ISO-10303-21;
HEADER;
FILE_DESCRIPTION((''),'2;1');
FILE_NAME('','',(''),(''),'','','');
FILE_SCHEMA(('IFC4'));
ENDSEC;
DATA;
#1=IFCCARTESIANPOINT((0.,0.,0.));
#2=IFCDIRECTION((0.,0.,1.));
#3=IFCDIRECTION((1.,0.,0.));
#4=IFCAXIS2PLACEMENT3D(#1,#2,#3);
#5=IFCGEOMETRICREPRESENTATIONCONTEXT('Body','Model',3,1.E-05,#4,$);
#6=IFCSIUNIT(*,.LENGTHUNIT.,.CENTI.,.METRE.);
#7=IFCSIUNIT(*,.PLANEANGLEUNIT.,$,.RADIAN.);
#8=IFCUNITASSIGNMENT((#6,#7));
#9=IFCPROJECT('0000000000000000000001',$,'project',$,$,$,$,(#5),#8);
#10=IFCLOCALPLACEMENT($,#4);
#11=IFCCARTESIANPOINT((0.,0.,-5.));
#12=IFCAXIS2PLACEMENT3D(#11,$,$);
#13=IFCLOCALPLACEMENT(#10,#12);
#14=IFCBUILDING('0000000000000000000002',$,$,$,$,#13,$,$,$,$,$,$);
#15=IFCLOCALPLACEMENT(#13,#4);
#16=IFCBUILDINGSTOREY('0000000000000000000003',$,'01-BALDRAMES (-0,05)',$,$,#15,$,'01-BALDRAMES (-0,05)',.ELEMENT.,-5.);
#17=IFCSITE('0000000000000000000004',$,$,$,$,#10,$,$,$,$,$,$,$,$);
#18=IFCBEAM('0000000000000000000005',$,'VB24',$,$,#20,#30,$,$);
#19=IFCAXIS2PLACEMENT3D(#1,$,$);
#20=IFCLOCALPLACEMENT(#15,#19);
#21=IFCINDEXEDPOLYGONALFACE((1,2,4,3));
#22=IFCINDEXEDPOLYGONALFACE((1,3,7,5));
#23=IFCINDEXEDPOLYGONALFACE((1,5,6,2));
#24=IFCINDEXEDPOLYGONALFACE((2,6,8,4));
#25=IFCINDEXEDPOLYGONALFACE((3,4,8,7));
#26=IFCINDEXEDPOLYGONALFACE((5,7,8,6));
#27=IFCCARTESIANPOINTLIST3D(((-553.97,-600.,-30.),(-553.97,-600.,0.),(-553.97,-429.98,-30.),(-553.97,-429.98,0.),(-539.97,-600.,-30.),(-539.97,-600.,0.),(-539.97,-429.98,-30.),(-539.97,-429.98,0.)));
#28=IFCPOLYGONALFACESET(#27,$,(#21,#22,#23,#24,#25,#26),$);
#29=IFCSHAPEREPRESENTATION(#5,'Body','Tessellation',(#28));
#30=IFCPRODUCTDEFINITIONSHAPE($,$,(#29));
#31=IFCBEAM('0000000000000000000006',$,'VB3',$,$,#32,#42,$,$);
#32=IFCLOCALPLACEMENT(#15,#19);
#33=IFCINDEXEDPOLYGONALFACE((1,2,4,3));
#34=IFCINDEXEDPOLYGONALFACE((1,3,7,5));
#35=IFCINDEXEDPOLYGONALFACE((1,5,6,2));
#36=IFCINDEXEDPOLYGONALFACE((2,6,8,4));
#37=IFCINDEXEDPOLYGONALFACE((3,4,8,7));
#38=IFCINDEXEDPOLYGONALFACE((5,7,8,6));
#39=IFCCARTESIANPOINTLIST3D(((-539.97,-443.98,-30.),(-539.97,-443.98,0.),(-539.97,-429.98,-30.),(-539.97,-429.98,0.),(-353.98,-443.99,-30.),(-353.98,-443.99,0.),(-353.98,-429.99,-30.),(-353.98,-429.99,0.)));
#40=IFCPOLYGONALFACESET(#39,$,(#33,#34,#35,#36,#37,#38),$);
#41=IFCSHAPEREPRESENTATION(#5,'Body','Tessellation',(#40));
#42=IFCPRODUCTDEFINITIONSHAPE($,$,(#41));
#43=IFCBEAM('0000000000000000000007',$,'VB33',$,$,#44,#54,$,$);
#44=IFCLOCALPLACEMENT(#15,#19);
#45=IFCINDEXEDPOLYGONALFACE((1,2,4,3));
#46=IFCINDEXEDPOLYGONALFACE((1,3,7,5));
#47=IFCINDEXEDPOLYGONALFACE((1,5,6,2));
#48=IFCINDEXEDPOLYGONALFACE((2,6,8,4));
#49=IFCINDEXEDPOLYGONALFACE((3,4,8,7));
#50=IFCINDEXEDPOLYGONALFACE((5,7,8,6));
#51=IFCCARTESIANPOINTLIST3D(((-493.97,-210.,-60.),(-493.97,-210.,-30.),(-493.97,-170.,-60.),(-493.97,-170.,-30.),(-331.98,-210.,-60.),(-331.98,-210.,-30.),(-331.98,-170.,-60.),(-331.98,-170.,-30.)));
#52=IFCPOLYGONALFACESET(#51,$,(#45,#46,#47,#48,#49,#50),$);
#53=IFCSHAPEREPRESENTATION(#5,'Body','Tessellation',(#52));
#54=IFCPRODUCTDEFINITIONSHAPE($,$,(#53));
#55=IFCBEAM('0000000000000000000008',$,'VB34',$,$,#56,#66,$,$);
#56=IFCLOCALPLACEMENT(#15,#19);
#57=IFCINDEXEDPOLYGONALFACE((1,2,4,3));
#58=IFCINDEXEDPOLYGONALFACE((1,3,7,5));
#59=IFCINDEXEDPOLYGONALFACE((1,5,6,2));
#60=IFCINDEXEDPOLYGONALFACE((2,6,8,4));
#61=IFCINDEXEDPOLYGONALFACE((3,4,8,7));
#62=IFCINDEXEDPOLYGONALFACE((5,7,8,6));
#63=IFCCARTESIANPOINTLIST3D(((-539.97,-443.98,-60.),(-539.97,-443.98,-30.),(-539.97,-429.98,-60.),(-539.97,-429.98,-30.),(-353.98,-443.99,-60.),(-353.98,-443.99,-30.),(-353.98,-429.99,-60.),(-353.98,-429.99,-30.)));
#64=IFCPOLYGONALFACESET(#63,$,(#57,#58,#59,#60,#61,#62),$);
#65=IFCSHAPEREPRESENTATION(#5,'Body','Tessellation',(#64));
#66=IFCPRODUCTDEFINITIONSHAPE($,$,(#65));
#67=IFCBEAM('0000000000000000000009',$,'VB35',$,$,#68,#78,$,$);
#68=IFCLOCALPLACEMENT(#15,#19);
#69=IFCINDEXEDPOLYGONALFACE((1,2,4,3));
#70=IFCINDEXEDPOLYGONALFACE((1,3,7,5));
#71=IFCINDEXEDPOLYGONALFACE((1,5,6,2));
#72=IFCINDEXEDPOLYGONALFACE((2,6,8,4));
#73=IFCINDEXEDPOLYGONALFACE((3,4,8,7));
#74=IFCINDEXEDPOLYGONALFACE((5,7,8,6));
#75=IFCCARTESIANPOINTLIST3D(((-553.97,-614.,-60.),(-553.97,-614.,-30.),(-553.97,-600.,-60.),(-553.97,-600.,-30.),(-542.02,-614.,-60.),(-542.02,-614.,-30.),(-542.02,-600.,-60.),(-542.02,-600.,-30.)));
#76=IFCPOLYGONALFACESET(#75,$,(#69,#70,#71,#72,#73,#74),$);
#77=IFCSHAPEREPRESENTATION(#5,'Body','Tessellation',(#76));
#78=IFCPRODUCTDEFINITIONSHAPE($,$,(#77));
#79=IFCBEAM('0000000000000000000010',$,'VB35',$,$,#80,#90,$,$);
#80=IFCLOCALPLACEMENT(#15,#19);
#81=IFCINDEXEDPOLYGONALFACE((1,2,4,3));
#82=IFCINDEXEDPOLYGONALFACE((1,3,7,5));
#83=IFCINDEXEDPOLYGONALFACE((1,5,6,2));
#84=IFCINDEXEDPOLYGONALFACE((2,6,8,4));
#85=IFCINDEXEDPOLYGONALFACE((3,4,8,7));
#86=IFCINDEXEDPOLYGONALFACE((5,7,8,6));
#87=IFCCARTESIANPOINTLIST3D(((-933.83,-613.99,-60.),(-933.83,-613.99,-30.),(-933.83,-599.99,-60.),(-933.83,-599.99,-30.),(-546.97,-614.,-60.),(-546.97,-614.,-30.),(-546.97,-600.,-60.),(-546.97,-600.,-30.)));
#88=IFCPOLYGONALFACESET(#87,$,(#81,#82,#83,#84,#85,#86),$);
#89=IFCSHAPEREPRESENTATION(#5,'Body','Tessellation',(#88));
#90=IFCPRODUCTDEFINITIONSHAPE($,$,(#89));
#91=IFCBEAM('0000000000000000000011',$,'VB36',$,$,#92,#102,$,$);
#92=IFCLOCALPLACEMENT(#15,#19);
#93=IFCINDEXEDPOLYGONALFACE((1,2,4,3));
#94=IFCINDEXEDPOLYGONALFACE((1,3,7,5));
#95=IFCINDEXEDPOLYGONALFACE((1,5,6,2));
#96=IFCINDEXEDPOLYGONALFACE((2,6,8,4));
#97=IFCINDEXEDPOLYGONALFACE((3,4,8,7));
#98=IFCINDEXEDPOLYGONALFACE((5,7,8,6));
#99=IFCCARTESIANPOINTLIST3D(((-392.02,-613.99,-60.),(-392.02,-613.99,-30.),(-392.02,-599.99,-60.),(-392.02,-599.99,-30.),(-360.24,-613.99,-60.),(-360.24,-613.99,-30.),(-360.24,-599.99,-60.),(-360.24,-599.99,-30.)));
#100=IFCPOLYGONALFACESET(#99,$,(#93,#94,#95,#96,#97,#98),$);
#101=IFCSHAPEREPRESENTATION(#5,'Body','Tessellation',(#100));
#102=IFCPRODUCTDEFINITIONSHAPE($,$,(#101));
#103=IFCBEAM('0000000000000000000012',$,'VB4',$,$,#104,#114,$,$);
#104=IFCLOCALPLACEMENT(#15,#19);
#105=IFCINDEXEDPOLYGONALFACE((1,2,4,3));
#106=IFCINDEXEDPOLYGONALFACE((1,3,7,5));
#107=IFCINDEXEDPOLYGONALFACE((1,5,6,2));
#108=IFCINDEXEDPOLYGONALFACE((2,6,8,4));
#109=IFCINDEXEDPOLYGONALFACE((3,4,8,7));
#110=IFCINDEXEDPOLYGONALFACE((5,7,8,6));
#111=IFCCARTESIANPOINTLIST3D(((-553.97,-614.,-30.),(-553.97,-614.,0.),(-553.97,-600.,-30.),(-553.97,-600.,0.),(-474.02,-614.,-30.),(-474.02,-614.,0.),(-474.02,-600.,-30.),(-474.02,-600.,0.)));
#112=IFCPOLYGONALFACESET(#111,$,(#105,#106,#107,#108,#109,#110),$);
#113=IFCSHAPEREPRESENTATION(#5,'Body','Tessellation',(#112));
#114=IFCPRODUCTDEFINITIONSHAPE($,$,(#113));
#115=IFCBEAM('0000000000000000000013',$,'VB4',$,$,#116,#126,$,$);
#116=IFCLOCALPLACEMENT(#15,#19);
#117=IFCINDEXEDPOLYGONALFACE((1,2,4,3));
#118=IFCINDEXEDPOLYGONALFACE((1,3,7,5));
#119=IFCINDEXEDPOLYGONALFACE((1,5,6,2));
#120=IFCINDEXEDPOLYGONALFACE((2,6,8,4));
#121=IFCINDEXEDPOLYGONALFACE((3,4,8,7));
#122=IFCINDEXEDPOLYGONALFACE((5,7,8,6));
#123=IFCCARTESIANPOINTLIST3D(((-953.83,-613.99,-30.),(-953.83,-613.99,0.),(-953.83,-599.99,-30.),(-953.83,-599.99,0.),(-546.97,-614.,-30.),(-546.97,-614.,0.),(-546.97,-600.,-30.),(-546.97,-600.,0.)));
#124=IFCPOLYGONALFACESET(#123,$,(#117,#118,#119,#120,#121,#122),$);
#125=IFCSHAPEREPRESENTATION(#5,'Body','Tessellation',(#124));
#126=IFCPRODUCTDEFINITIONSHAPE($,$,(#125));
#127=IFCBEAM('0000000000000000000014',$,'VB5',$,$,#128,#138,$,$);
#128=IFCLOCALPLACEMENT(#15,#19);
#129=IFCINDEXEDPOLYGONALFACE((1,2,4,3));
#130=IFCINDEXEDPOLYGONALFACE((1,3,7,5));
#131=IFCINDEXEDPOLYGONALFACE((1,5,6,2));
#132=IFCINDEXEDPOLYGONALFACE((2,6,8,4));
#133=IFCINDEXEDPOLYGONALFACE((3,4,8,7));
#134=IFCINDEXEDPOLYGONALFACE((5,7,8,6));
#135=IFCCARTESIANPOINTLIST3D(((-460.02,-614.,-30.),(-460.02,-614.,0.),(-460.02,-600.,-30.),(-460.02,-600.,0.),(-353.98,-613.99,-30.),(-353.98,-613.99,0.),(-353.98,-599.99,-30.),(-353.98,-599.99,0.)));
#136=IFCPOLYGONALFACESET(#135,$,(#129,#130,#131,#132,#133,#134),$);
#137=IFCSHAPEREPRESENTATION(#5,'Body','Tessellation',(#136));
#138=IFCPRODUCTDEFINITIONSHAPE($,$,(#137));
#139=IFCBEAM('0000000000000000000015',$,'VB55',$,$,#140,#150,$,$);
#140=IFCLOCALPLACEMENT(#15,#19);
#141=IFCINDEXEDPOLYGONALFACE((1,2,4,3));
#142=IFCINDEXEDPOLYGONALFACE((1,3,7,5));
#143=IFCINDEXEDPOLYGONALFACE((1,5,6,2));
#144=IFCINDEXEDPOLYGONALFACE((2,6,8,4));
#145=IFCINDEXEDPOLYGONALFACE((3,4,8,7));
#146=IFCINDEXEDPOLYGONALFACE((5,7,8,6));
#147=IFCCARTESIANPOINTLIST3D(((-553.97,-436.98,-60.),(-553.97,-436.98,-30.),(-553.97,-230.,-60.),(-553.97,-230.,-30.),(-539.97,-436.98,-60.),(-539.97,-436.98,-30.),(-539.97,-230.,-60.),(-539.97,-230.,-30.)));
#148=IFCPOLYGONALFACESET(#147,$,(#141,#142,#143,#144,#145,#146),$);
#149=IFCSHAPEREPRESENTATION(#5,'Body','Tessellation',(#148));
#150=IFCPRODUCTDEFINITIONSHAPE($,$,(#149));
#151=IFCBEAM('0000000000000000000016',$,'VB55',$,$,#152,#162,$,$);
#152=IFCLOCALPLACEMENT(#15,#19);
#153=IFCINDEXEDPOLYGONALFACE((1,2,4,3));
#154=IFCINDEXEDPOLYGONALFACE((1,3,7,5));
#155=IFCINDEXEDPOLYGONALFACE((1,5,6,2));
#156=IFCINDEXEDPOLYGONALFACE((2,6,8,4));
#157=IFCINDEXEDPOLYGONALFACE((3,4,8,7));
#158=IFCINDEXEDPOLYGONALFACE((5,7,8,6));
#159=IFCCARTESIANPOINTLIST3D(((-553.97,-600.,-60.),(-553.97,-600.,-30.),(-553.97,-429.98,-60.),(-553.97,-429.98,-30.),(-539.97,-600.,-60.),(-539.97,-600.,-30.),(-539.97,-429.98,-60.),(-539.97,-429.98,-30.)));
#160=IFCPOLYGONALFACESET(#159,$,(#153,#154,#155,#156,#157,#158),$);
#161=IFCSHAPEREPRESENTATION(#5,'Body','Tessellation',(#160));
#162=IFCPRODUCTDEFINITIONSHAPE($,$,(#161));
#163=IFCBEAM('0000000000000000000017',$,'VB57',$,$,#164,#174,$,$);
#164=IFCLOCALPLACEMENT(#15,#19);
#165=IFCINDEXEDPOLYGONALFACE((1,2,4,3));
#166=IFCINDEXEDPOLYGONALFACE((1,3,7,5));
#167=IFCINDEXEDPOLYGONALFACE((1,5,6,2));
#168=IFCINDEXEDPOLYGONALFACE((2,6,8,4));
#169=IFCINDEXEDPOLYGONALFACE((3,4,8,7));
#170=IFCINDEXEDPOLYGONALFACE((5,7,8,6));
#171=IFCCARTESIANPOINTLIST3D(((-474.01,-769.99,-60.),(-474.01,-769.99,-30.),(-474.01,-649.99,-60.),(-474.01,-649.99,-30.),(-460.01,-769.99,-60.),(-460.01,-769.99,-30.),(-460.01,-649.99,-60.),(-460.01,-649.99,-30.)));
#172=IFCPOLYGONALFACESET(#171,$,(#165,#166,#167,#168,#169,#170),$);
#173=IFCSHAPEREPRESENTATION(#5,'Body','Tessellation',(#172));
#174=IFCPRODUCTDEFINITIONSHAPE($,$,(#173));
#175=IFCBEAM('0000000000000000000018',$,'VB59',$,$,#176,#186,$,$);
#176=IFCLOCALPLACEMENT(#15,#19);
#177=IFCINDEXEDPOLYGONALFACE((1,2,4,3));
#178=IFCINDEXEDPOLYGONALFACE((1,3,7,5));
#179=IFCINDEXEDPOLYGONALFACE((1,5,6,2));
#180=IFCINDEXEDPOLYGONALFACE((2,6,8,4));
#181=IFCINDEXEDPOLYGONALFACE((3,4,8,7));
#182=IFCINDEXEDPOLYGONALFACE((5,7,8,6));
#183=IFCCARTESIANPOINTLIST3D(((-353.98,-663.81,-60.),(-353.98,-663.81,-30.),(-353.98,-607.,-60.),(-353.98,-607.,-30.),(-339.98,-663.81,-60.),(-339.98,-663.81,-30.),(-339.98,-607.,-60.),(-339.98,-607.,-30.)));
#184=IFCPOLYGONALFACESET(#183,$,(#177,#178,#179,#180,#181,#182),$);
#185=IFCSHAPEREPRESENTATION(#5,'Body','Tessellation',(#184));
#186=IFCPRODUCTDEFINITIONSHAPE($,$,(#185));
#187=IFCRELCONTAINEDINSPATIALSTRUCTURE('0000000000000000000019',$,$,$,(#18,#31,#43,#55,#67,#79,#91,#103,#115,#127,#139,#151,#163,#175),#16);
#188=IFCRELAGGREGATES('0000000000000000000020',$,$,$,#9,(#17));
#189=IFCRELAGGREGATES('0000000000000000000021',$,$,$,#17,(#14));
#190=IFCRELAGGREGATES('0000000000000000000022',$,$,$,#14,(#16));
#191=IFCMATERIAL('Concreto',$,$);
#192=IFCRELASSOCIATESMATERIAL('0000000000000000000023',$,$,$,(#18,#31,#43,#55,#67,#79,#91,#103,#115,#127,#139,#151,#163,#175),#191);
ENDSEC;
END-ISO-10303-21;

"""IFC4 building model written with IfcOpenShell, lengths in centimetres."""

from ifc_helpers import new_model, si_unit, frame, origin_with_axes, origin_2d_with_axis, place, context, project, spatial, rectangle, extrude, material, element, save


model = new_model("IFC4")

# Units and contexts
model_context = context("Model", 3, precision=1e-05, world=origin_with_axes(), identifier="Body")
ifc_project = project(units=[si_unit("LENGTHUNIT", "METRE", prefix="CENTI"), si_unit("PLANEANGLEUNIT", "RADIAN")], contexts=[model_context])

# Site, building, storey
site_placement = place(None, origin_with_axes())
site = spatial("IfcSite", under=ifc_project, at=site_placement)
building_placement = place(site_placement, frame((0.0, 0.0, -5.0)))
building = spatial("IfcBuilding", under=site, at=building_placement)
storey_placement = place(building_placement, origin_with_axes())
storey = spatial("IfcBuildingStorey", under=building, at=storey_placement, Name="01-BALDRAMES (-0,05)", LongName="01-BALDRAMES (-0,05)", CompositionType="ELEMENT", Elevation=-5.0)

# Shared definitions
ifc_material = material(Name="Concreto")

# Beams
beam_1_placement = place(storey_placement, frame((-546.97, -514.99, 0.0), z_axis=(0.0, 0.0, 1.0), x_axis=(1.0, 0.0, 0.0)))
element("IfcBeam", 1, at=beam_1_placement, inside=storey, material=ifc_material, Name="VB24", context=model_context, shape_type="SolidModel", body=[
    extrude(rectangle(XDim=14.0, YDim=30.0, at=origin_2d_with_axis()), frame((0.0, -85.01, -15.0), z_axis=(0.0, 1.0, 0.0), x_axis=(-1.0, 0.0, 0.0)), (0.0, 0.0, 1.0), 170.02),
])
beam_2_placement = place(storey_placement, frame((-446.98, -436.99, 0.0), z_axis=(0.0, 0.0, 1.0), x_axis=(1.0, 0.0, 0.0)))
element("IfcBeam", 2, at=beam_2_placement, inside=storey, material=ifc_material, Name="VB3", context=model_context, shape_type="SolidModel", body=[
    extrude(rectangle(XDim=14.0, YDim=30.0, at=origin_2d_with_axis()), frame((-93.0, 0.0, -15.0), z_axis=(1.0, -0.00005, 0.0), x_axis=(-0.00005, -1.0, 0.0)), (0.0, 0.0, 1.0), 185.99),
])
beam_3_placement = place(storey_placement, frame((-412.98, -190.0, -30.0), z_axis=(0.0, 0.0, 1.0), x_axis=(1.0, 0.0, 0.0)))
element("IfcBeam", 3, at=beam_3_placement, inside=storey, material=ifc_material, Name="VB33", context=model_context, shape_type="SolidModel", body=[
    extrude(rectangle(XDim=40.0, YDim=30.0, at=origin_2d_with_axis()), frame((-81.0, 0.0, -15.0), z_axis=(1.0, 0.0, 0.0), x_axis=(0.0, -1.0, 0.0)), (0.0, 0.0, 1.0), 161.99),
])
beam_4_placement = place(storey_placement, frame((-446.98, -436.99, -30.0), z_axis=(0.0, 0.0, 1.0), x_axis=(1.0, 0.0, 0.0)))
element("IfcBeam", 4, at=beam_4_placement, inside=storey, material=ifc_material, Name="VB34", context=model_context, shape_type="SolidModel", body=[
    extrude(rectangle(XDim=14.0, YDim=30.0, at=origin_2d_with_axis()), frame((-93.0, 0.0, -15.0), z_axis=(1.0, -0.00005, 0.0), x_axis=(-0.00005, -1.0, 0.0)), (0.0, 0.0, 1.0), 185.99),
])
beam_5_placement = place(storey_placement, frame((-548.0, -607.0, -30.0), z_axis=(0.0, 0.0, 1.0), x_axis=(1.0, 0.0, 0.0)))
element("IfcBeam", 5, at=beam_5_placement, inside=storey, material=ifc_material, Name="VB35", context=model_context, shape_type="SolidModel", body=[
    extrude(rectangle(XDim=14.0, YDim=30.0, at=origin_2d_with_axis()), frame((-5.97, 0.0, -15.0), z_axis=(1.0, 0.0, 0.0), x_axis=(0.0, -1.0, 0.0)), (0.0, 0.0, 1.0), 11.95),
])
beam_6_placement = place(storey_placement, frame((-740.4, -607.0, -30.0), z_axis=(0.0, 0.0, 1.0), x_axis=(1.0, 0.0, 0.0)))
element("IfcBeam", 6, at=beam_6_placement, inside=storey, material=ifc_material, Name="VB35", context=model_context, shape_type="SolidModel", body=[
    extrude(rectangle(XDim=14.0, YDim=30.0, at=origin_2d_with_axis()), frame((-193.43, 0.01, -15.0), z_axis=(1.0, -0.000026, 0.0), x_axis=(-0.000026, -1.0, 0.0)), (0.0, 0.0, 1.0), 386.86),
])
beam_7_placement = place(storey_placement, frame((-376.13, -606.99, -30.0), z_axis=(0.0, 0.0, 1.0), x_axis=(1.0, 0.0, 0.0)))
element("IfcBeam", 7, at=beam_7_placement, inside=storey, material=ifc_material, Name="VB36", context=model_context, shape_type="SolidModel", body=[
    extrude(rectangle(XDim=14.0, YDim=30.0, at=origin_2d_with_axis()), frame((-15.89, 0.0, -15.0), z_axis=(1.0, 0.0, 0.0), x_axis=(0.0, -1.0, 0.0)), (0.0, 0.0, 1.0), 31.78),
])
beam_8_placement = place(storey_placement, frame((-514.0, -607.0, 0.0), z_axis=(0.0, 0.0, 1.0), x_axis=(1.0, 0.0, 0.0)))
element("IfcBeam", 8, at=beam_8_placement, inside=storey, material=ifc_material, Name="VB4", context=model_context, shape_type="SolidModel", body=[
    extrude(rectangle(XDim=14.0, YDim=30.0, at=origin_2d_with_axis()), frame((-39.98, 0.0, -15.0), z_axis=(1.0, 0.0, 0.0), x_axis=(0.0, -1.0, 0.0)), (0.0, 0.0, 1.0), 79.95),
])
beam_9_placement = place(storey_placement, frame((-750.4, -607.0, 0.0), z_axis=(0.0, 0.0, 1.0), x_axis=(1.0, 0.0, 0.0)))
element("IfcBeam", 9, at=beam_9_placement, inside=storey, material=ifc_material, Name="VB4", context=model_context, shape_type="SolidModel", body=[
    extrude(rectangle(XDim=14.0, YDim=30.0, at=origin_2d_with_axis()), frame((-203.43, 0.01, -15.0), z_axis=(1.0, -0.000025, 0.0), x_axis=(-0.000025, -1.0, 0.0)), (0.0, 0.0, 1.0), 406.86),
])
beam_10_placement = place(storey_placement, frame((-407.0, -607.0, 0.0), z_axis=(0.0, 0.0, 1.0), x_axis=(1.0, 0.0, 0.0)))
element("IfcBeam", 10, at=beam_10_placement, inside=storey, material=ifc_material, Name="VB5", context=model_context, shape_type="SolidModel", body=[
    extrude(rectangle(XDim=14.0, YDim=30.0, at=origin_2d_with_axis()), frame((-53.02, 0.0, -15.0), z_axis=(1.0, 0.000088, 0.0), x_axis=(0.000088, -1.0, 0.0)), (0.0, 0.0, 1.0), 106.04),
])
beam_11_placement = place(storey_placement, frame((-546.97, -333.49, -30.0), z_axis=(0.0, 0.0, 1.0), x_axis=(1.0, 0.0, 0.0)))
element("IfcBeam", 11, at=beam_11_placement, inside=storey, material=ifc_material, Name="VB55", context=model_context, shape_type="SolidModel", body=[
    extrude(rectangle(XDim=14.0, YDim=30.0, at=origin_2d_with_axis()), frame((0.0, -103.49, -15.0), z_axis=(0.0, 1.0, 0.0), x_axis=(-1.0, 0.0, 0.0)), (0.0, 0.0, 1.0), 206.98),
])
beam_12_placement = place(storey_placement, frame((-546.97, -514.99, -30.0), z_axis=(0.0, 0.0, 1.0), x_axis=(1.0, 0.0, 0.0)))
element("IfcBeam", 12, at=beam_12_placement, inside=storey, material=ifc_material, Name="VB55", context=model_context, shape_type="SolidModel", body=[
    extrude(rectangle(XDim=14.0, YDim=30.0, at=origin_2d_with_axis()), frame((0.0, -85.01, -15.0), z_axis=(0.0, 1.0, 0.0), x_axis=(-1.0, 0.0, 0.0)), (0.0, 0.0, 1.0), 170.02),
])
beam_13_placement = place(storey_placement, frame((-467.01, -709.99, -30.0), z_axis=(0.0, 0.0, 1.0), x_axis=(1.0, 0.0, 0.0)))
element("IfcBeam", 13, at=beam_13_placement, inside=storey, material=ifc_material, Name="VB57", context=model_context, shape_type="SolidModel", body=[
    extrude(rectangle(XDim=14.0, YDim=30.0, at=origin_2d_with_axis()), frame((0.0, -60.0, -15.0), z_axis=(0.0, 1.0, 0.0), x_axis=(1.0, 0.0, 0.0)), (0.0, 0.0, 1.0), 120.0),
])
beam_14_placement = place(storey_placement, frame((-346.98, -635.4, -30.0), z_axis=(0.0, 0.0, 1.0), x_axis=(1.0, 0.0, 0.0)))
element("IfcBeam", 14, at=beam_14_placement, inside=storey, material=ifc_material, Name="VB59", context=model_context, shape_type="SolidModel", body=[
    extrude(rectangle(XDim=14.0, YDim=30.0, at=origin_2d_with_axis()), frame((0.0, -28.41, -15.0), z_axis=(0.0, 1.0, 0.0), x_axis=(1.0, 0.0, 0.0)), (0.0, 0.0, 1.0), 56.81),
])

save(model, "model.ifc")
